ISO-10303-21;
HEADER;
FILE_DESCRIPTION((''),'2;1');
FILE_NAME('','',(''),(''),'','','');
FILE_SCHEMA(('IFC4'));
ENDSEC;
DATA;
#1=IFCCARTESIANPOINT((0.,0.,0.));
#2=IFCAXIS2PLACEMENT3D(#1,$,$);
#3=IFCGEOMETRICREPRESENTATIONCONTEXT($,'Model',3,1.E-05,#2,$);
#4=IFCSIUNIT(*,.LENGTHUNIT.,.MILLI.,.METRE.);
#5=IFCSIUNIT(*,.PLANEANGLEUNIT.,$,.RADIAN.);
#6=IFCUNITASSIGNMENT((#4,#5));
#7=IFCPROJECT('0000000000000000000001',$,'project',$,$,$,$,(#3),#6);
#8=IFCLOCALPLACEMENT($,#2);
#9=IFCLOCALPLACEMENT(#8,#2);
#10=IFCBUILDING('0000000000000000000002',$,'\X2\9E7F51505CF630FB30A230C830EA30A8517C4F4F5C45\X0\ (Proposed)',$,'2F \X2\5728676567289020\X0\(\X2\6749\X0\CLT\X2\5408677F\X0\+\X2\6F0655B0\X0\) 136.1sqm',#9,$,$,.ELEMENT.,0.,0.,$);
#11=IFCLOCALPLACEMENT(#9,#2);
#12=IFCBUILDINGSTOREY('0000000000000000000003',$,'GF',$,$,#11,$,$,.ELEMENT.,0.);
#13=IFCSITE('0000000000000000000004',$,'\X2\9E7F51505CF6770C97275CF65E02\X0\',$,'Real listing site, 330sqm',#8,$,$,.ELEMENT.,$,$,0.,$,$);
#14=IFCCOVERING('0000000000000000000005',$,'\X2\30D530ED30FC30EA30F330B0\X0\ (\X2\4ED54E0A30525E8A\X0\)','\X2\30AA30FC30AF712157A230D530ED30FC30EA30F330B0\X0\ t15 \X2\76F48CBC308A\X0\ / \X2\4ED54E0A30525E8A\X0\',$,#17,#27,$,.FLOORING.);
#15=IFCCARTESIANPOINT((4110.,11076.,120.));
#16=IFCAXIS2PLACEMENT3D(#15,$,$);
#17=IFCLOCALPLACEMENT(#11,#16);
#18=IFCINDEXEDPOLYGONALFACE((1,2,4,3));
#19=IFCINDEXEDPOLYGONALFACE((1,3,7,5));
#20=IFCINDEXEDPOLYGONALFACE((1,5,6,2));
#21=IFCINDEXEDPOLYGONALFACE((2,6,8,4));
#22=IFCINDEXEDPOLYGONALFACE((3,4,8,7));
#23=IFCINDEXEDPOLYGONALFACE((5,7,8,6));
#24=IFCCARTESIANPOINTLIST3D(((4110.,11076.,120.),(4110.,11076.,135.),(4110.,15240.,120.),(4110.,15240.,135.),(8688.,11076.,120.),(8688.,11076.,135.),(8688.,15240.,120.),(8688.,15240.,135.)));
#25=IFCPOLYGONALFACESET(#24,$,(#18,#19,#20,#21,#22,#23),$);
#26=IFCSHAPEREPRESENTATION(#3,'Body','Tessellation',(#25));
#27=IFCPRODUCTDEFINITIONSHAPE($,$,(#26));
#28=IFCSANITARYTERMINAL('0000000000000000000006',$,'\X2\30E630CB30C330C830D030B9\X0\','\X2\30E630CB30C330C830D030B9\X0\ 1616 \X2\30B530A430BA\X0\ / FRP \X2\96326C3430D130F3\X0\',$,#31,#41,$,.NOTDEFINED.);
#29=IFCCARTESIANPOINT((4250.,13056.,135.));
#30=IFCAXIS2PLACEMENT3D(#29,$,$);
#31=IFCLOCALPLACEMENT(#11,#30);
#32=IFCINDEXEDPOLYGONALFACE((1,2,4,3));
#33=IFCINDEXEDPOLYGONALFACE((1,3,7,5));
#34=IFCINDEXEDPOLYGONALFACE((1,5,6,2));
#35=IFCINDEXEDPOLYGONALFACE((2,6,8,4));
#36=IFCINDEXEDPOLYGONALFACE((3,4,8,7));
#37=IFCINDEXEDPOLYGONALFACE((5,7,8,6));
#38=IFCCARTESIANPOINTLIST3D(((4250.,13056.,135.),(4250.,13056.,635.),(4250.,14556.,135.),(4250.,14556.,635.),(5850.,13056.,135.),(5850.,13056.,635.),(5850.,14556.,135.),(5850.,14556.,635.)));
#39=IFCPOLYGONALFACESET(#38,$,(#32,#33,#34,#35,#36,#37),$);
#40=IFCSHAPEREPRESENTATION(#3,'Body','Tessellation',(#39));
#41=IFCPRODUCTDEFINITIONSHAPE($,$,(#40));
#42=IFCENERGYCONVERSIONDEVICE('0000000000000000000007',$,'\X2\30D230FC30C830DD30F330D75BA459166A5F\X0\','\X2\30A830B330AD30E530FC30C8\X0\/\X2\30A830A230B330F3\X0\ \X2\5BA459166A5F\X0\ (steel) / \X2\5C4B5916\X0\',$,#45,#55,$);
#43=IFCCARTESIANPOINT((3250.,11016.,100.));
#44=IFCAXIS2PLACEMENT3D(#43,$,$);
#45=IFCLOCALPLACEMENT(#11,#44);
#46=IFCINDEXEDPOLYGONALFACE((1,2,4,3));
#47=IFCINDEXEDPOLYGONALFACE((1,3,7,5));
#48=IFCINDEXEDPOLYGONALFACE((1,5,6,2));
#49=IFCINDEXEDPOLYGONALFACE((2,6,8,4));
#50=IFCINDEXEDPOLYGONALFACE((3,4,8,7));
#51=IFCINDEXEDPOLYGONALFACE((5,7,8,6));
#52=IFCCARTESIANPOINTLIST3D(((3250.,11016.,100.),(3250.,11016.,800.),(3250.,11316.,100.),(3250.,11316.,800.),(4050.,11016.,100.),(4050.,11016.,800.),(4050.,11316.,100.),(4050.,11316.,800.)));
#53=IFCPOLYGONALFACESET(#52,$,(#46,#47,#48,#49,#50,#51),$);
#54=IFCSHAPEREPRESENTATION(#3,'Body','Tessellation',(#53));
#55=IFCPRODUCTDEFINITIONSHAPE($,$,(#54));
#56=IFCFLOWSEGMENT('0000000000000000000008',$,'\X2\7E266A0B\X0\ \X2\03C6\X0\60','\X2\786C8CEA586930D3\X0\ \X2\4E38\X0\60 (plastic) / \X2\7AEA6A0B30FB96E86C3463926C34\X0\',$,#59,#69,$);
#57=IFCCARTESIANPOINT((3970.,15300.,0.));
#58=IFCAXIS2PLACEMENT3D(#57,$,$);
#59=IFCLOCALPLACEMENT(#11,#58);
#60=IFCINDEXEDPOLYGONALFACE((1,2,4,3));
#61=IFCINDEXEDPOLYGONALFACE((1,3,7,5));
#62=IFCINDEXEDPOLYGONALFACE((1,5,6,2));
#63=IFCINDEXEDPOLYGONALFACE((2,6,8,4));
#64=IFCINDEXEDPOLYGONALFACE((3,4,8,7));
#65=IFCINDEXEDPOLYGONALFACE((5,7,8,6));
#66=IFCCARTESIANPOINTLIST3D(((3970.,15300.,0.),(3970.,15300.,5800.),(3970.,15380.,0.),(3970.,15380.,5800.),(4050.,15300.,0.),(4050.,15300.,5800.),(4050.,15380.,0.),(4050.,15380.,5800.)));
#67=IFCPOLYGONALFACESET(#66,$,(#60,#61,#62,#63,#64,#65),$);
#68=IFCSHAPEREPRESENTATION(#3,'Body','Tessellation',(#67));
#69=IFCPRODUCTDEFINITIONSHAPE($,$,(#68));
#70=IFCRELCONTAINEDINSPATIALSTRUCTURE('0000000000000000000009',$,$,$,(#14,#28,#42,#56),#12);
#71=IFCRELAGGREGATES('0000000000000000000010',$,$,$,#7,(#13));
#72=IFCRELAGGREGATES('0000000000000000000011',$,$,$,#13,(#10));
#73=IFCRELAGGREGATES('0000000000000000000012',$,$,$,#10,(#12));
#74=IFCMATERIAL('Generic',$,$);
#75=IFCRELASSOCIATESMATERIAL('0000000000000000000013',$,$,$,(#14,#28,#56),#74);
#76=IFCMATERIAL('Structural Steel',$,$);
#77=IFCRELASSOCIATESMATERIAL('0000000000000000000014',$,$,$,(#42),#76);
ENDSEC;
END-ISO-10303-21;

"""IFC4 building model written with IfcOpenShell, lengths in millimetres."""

from ifc_helpers import new_model, si_unit, frame, frame_2d, origin, place, context, project, spatial, rectangle, extrude, material, element, save


model = new_model("IFC4")

# Units and contexts
model_context = context("Model", 3, precision=1e-05, world=origin())
ifc_project = project(units=[si_unit("LENGTHUNIT", "METRE", prefix="MILLI"), si_unit("PLANEANGLEUNIT", "RADIAN")], contexts=[model_context])

# Site, building, storey
site_placement = place(None, origin())
site = spatial("IfcSite", under=ifc_project, at=site_placement, Name="鹿児島県霧島市", ObjectType="Real listing site, 330sqm", CompositionType="ELEMENT", RefElevation=0.0)
building_placement = place(site_placement, origin())
building = spatial("IfcBuilding", under=site, at=building_placement, Name="鹿児島・アトリエ兼住居 (Proposed)", ObjectType="2F 在来木造(杉CLT合板+漆喰) 136.1sqm", CompositionType="ELEMENT", ElevationOfRefHeight=0.0, ElevationOfTerrain=0.0)
storey_placement = place(building_placement, origin())
storey = spatial("IfcBuildingStorey", under=building, at=storey_placement, Name="GF", CompositionType="ELEMENT", Elevation=0.0)

# Covering
ifc_material_1 = material(Name="Generic")
covering_placement = place(storey_placement, frame((4110.0, 11076.0, 120.0)))
element("IfcCovering", 1, at=covering_placement, inside=storey, material=ifc_material_1, Name="フローリング (仕上げ床)", Description="オーク無垢フローリング t15 直貼り / 仕上げ床", PredefinedType="FLOORING", context=model_context, shape_type="SweptSolid", body=[
    extrude(rectangle(XDim=4578.0, YDim=4164.0, at=frame_2d((2289.0, 2082.0))), frame((4110.0, 11076.0, 120.0)), (0.0, 0.0, 1.0), 15.0),
])

# Sanitary terminal
sanitary_terminal_placement = place(storey_placement, frame((4250.0, 13056.0, 135.0)))
element("IfcSanitaryTerminal", 2, at=sanitary_terminal_placement, inside=storey, material=ifc_material_1, Name="ユニットバス", Description="ユニットバス 1616 サイズ / FRP 防水パン", PredefinedType="NOTDEFINED", context=model_context, shape_type="SweptSolid", body=[
    extrude(rectangle(XDim=1600.0, YDim=1500.0, at=frame_2d((800.0, 750.0))), frame((4250.0, 13056.0, 135.0)), (0.0, 0.0, 1.0), 500.0),
])

# Energy conversion device
ifc_material_2 = material(Name="Structural Steel")
energy_conversion_device_placement = place(storey_placement, frame((3250.0, 11016.0, 100.0)))
element("IfcEnergyConversionDevice", 3, at=energy_conversion_device_placement, inside=storey, material=ifc_material_2, Name="ヒートポンプ室外機", Description="エコキュート/エアコン 室外機 (steel) / 屋外", context=model_context, shape_type="SweptSolid", body=[
    extrude(rectangle(XDim=800.0, YDim=300.0, at=frame_2d((400.0, 150.0))), frame((3250.0, 11016.0, 100.0)), (0.0, 0.0, 1.0), 700.0),
])

# Flow segment
flow_segment_placement = place(storey_placement, frame((3970.0, 15300.0, 0.0)))
element("IfcFlowSegment", 4, at=flow_segment_placement, inside=storey, material=ifc_material_1, Name="縦樋 φ60", Description="硬質塩ビ 丸60 (plastic) / 竪樋・雨水排水", context=model_context, shape_type="SweptSolid", body=[
    extrude(rectangle(XDim=80.0, YDim=80.0, at=frame_2d((40.0, 40.0))), frame((3970.0, 15300.0, 0.0)), (0.0, 0.0, 1.0), 5800.0),
])

save(model, "model.ifc")
